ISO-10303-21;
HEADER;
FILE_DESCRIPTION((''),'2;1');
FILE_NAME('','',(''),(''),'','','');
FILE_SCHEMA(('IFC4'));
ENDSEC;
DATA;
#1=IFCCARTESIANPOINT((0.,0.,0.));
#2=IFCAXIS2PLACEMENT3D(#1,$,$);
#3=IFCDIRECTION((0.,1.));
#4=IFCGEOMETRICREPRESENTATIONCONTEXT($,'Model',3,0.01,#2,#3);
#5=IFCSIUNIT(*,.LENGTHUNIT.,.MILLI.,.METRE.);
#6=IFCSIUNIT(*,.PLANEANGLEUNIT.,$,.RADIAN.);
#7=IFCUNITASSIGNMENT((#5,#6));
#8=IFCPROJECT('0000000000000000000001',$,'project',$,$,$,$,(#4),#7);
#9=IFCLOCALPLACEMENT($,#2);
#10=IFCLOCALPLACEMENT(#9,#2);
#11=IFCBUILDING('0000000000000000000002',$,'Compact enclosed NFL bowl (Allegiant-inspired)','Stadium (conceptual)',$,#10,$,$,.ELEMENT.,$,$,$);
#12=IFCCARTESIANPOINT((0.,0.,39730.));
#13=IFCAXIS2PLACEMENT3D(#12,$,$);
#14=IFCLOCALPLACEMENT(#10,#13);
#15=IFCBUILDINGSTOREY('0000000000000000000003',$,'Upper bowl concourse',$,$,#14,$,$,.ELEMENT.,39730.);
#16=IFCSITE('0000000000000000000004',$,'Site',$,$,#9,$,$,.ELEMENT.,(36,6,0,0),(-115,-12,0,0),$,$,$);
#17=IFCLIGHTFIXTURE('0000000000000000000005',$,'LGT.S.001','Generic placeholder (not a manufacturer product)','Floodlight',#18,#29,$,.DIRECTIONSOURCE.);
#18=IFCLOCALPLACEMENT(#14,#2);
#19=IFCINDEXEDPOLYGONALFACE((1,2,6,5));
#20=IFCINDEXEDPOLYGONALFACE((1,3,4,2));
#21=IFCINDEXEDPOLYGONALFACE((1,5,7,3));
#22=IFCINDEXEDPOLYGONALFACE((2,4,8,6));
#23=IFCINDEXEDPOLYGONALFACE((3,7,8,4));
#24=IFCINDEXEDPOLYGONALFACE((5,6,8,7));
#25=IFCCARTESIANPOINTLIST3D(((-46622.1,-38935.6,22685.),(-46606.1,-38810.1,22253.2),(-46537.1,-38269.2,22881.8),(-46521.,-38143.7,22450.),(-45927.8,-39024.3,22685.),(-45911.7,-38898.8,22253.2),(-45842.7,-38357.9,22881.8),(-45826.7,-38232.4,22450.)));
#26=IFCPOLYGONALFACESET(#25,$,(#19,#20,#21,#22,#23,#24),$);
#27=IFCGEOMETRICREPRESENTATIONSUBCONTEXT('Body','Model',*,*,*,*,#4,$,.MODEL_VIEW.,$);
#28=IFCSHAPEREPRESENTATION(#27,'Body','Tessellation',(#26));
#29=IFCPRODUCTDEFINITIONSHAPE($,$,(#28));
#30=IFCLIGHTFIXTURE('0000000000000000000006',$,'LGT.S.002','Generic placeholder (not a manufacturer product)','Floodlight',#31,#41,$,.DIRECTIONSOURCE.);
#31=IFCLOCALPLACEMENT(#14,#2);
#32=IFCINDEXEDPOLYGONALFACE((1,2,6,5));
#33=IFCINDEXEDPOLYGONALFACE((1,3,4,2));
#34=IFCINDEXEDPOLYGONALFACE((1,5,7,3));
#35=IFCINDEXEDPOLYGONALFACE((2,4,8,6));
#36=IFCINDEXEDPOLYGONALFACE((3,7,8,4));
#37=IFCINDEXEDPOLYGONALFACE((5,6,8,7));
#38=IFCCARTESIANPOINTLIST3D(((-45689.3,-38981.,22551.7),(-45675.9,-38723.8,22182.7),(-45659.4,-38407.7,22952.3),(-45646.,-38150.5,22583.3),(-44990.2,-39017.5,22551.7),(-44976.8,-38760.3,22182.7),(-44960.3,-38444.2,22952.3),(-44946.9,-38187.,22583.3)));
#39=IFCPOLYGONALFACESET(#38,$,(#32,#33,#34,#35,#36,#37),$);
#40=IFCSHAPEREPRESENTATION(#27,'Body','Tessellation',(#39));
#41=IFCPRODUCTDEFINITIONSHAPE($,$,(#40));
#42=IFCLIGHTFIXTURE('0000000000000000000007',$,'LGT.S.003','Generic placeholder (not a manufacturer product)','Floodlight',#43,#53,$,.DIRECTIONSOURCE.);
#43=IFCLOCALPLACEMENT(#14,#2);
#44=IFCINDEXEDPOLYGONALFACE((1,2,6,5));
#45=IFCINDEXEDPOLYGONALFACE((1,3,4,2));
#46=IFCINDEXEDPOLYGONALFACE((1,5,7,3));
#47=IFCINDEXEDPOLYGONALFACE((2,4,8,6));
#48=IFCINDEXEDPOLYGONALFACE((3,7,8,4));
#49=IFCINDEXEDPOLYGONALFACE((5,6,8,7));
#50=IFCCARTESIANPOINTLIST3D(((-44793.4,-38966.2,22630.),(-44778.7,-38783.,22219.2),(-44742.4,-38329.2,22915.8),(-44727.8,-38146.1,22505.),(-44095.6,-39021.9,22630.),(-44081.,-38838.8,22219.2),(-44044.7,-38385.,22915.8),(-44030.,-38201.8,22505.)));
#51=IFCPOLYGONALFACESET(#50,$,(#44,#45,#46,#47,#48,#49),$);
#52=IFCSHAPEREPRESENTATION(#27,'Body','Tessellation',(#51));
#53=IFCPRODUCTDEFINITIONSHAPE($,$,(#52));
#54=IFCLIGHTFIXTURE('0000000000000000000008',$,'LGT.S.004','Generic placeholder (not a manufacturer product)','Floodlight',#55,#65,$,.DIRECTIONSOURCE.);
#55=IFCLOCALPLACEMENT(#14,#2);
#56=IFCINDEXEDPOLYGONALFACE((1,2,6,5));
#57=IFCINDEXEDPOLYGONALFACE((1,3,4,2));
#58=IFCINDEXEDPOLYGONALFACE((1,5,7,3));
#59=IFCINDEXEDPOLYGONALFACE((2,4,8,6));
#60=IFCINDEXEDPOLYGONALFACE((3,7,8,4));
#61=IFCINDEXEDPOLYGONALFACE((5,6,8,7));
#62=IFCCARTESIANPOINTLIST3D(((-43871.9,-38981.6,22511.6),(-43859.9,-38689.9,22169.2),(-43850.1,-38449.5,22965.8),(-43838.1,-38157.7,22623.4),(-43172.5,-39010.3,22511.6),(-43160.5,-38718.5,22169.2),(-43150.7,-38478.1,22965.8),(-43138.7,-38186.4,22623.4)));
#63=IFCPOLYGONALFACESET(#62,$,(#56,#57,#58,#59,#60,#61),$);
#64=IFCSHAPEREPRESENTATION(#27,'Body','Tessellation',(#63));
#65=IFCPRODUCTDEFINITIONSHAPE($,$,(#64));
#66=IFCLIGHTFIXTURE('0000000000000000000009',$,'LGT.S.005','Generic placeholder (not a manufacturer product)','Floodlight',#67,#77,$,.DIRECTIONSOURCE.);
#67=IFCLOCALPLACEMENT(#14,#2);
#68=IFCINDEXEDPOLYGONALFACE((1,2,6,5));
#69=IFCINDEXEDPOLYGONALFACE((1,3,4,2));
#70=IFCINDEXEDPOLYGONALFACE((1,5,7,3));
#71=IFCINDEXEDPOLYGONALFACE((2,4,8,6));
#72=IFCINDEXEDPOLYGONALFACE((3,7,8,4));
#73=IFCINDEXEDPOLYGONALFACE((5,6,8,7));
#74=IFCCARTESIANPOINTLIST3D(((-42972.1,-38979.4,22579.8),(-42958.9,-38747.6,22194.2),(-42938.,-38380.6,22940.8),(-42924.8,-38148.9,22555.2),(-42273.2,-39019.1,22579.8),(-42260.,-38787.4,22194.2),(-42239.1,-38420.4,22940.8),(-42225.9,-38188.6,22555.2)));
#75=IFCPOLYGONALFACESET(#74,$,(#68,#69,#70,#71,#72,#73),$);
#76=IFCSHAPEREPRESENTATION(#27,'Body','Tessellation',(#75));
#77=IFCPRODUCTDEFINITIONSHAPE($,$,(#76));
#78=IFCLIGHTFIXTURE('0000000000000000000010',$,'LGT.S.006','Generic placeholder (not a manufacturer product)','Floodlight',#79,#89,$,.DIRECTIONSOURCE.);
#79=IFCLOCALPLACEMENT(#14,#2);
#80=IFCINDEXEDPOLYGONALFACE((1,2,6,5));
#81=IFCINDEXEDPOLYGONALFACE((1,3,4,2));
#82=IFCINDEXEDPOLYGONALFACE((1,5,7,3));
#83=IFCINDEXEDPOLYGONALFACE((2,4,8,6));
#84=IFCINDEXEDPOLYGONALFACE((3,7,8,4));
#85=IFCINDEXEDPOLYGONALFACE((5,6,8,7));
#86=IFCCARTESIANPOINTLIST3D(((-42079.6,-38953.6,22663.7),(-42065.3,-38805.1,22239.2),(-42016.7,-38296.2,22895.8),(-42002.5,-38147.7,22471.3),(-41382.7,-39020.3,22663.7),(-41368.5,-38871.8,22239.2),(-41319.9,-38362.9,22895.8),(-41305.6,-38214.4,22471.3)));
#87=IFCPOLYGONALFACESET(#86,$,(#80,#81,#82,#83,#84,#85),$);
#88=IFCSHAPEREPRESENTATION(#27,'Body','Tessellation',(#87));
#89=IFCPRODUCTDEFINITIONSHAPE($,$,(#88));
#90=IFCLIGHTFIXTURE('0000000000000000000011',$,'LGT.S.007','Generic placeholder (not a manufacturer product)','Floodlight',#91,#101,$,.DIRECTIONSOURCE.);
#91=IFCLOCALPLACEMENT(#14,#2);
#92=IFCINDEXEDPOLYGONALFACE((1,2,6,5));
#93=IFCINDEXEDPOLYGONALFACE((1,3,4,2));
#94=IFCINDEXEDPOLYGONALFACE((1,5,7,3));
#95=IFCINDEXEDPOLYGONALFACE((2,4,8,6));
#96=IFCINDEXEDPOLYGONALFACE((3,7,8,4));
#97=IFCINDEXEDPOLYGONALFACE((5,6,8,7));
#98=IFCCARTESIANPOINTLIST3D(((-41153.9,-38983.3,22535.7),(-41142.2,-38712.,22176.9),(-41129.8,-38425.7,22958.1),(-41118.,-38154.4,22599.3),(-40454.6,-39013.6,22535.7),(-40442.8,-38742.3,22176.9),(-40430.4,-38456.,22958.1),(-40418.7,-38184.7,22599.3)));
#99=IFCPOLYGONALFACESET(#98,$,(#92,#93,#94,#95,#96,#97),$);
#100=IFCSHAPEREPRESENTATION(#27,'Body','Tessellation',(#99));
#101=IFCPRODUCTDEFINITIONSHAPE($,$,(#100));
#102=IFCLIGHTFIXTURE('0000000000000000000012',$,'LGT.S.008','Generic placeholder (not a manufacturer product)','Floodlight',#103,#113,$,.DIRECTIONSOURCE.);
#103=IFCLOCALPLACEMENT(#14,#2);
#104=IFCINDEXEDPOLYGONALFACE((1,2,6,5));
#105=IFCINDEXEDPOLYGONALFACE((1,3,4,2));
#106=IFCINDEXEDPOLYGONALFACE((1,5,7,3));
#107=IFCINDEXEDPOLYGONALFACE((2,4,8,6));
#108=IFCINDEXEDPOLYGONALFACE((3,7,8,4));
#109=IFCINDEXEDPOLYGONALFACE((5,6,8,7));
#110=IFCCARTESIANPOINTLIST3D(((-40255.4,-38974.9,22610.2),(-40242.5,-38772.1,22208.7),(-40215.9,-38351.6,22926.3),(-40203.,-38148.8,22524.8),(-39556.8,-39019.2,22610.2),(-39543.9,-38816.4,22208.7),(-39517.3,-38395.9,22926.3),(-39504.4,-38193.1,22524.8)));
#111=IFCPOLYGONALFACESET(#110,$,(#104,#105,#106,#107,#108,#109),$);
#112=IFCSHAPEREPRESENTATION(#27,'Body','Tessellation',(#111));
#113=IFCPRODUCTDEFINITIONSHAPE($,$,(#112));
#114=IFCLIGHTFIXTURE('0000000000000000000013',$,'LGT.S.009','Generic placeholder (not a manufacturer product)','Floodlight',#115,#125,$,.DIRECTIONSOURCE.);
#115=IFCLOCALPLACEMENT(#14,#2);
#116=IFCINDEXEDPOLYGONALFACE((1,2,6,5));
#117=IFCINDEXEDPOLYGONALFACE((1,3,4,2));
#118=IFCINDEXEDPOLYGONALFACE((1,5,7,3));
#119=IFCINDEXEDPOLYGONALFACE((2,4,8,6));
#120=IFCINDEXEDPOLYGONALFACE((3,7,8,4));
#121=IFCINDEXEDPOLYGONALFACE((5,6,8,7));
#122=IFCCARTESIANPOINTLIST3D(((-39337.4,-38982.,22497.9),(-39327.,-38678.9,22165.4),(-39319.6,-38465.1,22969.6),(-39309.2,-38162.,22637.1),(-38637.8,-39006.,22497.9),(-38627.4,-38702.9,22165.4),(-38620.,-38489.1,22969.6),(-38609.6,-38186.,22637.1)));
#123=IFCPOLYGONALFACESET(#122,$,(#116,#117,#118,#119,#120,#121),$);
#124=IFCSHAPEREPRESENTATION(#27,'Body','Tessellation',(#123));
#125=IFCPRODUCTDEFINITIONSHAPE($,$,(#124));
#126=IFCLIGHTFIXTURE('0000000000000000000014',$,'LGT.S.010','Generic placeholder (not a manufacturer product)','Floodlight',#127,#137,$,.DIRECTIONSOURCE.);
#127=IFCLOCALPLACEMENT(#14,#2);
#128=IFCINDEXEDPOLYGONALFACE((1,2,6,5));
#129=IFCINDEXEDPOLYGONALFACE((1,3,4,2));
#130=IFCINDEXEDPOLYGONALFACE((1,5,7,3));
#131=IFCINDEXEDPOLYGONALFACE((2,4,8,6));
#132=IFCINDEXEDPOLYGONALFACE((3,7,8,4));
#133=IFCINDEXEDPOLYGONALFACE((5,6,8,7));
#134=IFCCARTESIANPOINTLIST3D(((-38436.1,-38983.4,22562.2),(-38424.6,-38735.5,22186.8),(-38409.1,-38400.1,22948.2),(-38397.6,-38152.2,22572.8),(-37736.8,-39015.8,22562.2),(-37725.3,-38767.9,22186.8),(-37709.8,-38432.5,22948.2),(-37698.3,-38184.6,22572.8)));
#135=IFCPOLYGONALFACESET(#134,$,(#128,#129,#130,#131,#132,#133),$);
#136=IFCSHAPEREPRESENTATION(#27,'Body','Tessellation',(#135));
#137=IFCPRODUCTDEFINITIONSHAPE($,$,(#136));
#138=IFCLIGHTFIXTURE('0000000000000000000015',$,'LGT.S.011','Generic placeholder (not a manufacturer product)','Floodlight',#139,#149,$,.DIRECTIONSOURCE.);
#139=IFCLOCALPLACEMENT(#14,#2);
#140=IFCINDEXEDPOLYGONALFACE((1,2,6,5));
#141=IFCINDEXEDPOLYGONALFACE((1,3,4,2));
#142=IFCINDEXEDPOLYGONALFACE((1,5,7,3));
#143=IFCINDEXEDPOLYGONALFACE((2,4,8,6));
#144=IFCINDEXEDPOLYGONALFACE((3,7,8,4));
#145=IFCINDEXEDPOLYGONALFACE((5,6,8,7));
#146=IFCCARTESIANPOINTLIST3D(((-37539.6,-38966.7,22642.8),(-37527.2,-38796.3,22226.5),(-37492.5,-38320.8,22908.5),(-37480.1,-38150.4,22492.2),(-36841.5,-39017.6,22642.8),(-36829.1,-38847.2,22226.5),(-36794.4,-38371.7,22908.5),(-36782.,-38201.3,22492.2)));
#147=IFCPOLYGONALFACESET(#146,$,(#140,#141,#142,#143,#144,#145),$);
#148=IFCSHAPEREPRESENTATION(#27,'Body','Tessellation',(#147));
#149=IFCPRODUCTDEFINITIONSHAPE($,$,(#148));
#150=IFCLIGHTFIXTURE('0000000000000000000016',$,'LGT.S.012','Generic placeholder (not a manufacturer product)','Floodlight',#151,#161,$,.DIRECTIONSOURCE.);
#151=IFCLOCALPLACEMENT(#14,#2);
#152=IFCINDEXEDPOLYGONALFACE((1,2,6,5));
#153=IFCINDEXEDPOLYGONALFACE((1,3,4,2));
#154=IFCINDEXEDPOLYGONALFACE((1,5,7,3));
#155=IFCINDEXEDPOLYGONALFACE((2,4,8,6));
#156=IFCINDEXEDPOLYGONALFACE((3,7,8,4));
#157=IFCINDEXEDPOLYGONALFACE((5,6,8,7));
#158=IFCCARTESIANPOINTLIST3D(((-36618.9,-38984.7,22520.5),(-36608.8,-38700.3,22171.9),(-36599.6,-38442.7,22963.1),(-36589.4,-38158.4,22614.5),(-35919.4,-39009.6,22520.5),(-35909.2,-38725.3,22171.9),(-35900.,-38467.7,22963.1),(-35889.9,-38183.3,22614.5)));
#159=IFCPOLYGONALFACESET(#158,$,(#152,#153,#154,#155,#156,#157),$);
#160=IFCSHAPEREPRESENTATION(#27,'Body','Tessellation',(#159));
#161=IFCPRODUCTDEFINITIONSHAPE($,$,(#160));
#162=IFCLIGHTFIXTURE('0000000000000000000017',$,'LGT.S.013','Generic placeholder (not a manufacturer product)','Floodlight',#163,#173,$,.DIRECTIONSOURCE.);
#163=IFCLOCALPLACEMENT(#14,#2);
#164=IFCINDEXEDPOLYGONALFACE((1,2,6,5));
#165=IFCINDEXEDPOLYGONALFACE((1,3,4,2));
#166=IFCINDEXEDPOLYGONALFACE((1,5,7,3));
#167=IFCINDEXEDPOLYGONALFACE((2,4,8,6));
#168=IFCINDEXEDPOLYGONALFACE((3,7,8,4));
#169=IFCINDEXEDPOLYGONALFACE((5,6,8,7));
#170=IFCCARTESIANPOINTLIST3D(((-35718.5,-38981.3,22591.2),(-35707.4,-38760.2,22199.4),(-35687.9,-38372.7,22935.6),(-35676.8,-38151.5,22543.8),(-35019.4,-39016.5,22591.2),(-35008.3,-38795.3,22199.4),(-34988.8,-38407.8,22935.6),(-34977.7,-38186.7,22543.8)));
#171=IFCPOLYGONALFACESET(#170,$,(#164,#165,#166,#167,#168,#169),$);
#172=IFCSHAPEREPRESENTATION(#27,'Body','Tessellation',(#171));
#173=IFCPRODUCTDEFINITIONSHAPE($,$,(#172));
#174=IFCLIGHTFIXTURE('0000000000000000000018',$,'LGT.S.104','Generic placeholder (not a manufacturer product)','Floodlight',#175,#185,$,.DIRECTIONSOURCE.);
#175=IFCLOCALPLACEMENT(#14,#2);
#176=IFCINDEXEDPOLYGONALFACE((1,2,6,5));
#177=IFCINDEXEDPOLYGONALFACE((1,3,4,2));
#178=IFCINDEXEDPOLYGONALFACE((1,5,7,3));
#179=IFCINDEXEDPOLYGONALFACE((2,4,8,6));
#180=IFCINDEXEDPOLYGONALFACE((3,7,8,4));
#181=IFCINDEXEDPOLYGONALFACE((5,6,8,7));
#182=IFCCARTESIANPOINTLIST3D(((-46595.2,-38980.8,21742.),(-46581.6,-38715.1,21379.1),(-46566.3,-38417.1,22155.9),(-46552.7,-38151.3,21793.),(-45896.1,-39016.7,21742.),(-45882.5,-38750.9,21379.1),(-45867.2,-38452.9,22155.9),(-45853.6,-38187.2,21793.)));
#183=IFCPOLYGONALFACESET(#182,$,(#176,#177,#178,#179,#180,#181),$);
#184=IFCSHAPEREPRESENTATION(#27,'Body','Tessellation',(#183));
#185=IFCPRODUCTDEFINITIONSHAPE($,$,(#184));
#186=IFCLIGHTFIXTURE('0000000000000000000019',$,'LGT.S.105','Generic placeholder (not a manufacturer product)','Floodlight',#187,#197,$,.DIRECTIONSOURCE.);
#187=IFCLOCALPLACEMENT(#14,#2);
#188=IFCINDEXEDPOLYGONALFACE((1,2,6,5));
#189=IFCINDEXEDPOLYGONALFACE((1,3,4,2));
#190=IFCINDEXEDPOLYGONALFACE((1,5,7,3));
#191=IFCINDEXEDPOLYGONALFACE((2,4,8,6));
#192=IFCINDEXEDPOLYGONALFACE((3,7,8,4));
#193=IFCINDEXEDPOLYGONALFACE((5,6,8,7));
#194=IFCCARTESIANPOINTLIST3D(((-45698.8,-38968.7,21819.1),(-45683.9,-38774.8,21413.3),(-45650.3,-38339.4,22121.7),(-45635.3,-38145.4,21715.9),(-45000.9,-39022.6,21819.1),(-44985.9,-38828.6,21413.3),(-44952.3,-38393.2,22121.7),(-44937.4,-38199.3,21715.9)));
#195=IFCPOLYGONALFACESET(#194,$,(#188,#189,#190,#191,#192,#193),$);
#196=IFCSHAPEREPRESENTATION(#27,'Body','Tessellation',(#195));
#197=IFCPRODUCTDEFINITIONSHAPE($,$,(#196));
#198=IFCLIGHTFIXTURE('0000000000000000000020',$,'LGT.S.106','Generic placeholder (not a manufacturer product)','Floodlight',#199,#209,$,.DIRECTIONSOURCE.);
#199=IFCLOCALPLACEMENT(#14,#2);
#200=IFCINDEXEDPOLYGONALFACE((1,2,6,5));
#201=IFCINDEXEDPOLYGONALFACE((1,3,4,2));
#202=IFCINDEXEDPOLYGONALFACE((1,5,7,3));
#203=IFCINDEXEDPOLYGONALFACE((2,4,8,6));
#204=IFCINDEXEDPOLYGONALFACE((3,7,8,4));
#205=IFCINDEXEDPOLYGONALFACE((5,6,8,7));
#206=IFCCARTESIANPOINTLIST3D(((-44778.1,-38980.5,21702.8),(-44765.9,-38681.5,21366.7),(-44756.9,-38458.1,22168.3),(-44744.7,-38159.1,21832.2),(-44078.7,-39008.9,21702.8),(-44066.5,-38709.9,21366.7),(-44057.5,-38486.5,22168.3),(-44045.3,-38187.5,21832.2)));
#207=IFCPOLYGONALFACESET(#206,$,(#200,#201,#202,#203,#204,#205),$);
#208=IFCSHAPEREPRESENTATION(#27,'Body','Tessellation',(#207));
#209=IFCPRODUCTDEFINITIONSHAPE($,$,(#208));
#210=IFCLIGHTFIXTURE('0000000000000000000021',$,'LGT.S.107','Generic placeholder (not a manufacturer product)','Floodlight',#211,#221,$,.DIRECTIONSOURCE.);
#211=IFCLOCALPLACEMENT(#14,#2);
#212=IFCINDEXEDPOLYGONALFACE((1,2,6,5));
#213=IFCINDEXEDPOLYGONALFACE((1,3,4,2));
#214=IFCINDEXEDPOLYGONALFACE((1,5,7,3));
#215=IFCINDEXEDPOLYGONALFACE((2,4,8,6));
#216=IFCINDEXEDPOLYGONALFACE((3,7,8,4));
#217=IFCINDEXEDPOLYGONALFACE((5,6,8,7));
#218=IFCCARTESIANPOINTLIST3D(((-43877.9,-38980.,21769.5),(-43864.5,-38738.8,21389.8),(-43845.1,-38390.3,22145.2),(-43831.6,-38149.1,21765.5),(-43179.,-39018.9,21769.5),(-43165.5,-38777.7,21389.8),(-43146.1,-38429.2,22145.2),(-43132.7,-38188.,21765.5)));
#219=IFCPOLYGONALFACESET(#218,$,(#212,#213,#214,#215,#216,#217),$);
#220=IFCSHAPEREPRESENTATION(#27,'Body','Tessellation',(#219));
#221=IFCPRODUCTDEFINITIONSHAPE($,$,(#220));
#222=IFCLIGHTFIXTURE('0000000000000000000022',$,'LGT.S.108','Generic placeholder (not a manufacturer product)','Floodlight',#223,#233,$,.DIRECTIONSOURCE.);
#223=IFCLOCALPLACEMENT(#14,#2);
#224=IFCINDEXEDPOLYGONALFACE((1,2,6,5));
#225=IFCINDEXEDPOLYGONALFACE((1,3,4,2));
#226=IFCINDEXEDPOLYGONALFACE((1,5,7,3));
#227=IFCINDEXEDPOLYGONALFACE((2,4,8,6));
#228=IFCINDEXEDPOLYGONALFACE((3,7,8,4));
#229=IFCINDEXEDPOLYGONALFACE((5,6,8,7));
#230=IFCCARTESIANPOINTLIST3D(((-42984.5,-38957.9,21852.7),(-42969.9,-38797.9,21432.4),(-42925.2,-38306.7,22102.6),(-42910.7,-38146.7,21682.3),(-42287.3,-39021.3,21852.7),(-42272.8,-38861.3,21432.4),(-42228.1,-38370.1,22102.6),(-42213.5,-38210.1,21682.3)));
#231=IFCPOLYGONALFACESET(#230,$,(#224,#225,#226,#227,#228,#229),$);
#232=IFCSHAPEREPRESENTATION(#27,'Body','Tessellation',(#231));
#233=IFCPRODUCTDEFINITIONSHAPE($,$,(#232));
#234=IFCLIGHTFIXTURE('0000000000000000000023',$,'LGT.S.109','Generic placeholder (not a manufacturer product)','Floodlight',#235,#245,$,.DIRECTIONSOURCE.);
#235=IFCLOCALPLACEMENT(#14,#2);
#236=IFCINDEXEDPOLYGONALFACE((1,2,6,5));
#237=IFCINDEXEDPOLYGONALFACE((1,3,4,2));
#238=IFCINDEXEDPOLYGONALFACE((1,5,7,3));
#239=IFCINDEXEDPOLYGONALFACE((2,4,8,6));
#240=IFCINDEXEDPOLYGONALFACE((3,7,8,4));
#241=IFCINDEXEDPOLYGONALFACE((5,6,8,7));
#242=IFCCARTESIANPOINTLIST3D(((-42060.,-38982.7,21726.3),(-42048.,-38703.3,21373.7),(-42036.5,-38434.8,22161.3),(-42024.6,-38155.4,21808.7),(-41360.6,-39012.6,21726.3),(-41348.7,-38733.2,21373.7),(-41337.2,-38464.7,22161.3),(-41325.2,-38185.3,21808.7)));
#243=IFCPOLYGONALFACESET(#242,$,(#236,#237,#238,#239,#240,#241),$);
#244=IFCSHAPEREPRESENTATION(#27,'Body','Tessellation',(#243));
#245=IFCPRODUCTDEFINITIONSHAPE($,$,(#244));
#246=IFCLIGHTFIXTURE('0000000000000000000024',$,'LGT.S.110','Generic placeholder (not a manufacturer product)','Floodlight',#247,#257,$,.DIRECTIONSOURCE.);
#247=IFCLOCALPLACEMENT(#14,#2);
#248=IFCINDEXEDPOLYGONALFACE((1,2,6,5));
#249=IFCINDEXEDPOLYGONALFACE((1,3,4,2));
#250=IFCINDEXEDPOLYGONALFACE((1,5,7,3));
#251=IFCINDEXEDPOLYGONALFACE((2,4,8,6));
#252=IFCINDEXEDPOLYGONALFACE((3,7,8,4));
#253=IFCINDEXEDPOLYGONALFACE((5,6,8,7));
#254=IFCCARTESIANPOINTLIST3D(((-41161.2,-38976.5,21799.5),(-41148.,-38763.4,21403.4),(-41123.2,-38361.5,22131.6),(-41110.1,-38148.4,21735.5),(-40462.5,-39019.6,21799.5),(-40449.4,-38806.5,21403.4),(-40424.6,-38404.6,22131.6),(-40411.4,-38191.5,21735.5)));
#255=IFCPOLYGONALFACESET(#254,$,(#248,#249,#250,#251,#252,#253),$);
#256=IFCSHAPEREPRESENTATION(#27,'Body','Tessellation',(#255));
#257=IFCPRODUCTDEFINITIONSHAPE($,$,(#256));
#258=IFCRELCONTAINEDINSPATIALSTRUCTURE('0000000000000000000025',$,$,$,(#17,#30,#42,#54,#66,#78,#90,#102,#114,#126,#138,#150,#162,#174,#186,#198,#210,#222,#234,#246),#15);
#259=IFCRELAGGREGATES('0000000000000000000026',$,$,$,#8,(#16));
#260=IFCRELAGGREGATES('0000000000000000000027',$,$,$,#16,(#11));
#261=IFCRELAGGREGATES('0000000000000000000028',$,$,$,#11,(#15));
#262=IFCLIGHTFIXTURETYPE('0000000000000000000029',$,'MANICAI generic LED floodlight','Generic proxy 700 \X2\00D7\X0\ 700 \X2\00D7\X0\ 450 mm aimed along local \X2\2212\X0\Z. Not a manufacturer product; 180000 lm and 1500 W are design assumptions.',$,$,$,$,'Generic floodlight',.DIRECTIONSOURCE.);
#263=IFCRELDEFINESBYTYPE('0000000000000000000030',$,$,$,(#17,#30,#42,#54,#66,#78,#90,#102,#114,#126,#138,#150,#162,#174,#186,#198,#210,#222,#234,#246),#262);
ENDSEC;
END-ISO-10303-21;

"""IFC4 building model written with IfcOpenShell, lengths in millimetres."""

from ifc_helpers import new_model, si_unit, direction, frame, origin, place, context, subcontext, project, spatial, rectangle, extrude, source, transform, mapped, type_object, type_shapes, element, save


model = new_model("IFC4")

# Units and contexts
model_context = context("Model", 3, precision=0.01, world=origin(), true_north=direction((0.0, 1.0)))
body_context = subcontext(model_context, "Body", "Model", "MODEL_VIEW")
ifc_project = project(units=[si_unit("LENGTHUNIT", "METRE", prefix="MILLI"), si_unit("PLANEANGLEUNIT", "RADIAN")], contexts=[model_context])

# Site, building, storey
site_placement = place(None, origin())
site = spatial("IfcSite", under=ifc_project, at=site_placement, Name="Site", CompositionType="ELEMENT", RefLatitude=(36, 6, 0, 0), RefLongitude=(-115, -12, 0, 0))
building_placement = place(site_placement, origin())
building = spatial("IfcBuilding", under=site, at=building_placement, Name="Compact enclosed NFL bowl (Allegiant-inspired)", Description="Stadium (conceptual)", CompositionType="ELEMENT")
storey_placement = place(building_placement, frame((0.0, 0.0, 39730.0)))
storey = spatial("IfcBuildingStorey", under=building, at=storey_placement, Name="Upper bowl concourse", CompositionType="ELEMENT", Elevation=39730.0)

# Light fixtures
light_fixture_type = type_object("IfcLightFixtureType", Name="MANICAI generic LED floodlight", Description="Generic proxy 700 × 700 × 450 mm aimed along local −Z. Not a manufacturer product; 180000 lm and 1500 W are design assumptions.", ElementType="Generic floodlight", PredefinedType="DIRECTIONSOURCE")
shared_shape = source(origin(), body_context, "Body", "SweptSolid", [
    extrude(rectangle(XDim=700.0, YDim=700.0), frame((0.0, 0.0, -225.0)), (0.0, 0.0, 1.0), 450.0),
])
type_shapes(light_fixture_type, [shared_shape])
for number, where, z_axis, x_axis, name in (
    (1, (-46224.4, -38584.0, 22567.5), (-0.035604, -0.278848, 0.959675), (0.991947, -0.126653, 0.0), "LGT.S.001"),
    (2, (-45318.1, -38584.0, 22567.5), (-0.029827, -0.571537, 0.820034), (0.998641, -0.052116, 0.0), "LGT.S.002"),
    (3, (-44411.7, -38584.0, 22567.5), (-0.032539, -0.406954, 0.912869), (0.996819, -0.079703, 0.0), "LGT.S.003"),
    (4, (-43505.3, -38584.0, 22567.5), (-0.026567, -0.64839, 0.760844), (0.999162, -0.040939, 0.0), "LGT.S.004"),
    (5, (-42599.0, -38584.0, 22567.5), (-0.029292, -0.514923, 0.856736), (0.998386, -0.056794, 0.0), "LGT.S.005"),
    (6, (-41692.6, -38584.0, 22567.5), (-0.03157, -0.330066, 0.94343), (0.995457, -0.095212, 0.0), "LGT.S.006"),
    (7, (-40786.3, -38584.0, 22567.5), (-0.026101, -0.602985, 0.797325), (0.999064, -0.043245, 0.0), "LGT.S.007"),
    (8, (-39879.9, -38584.0, 22567.5), (-0.028558, -0.45066, 0.892239), (0.997998, -0.063243, 0.0), "LGT.S.008"),
    (9, (-38973.5, -38584.0, 22567.5), (-0.023112, -0.673464, 0.738859), (0.999412, -0.034297, 0.0), "LGT.S.009"),
    (10, (-38067.2, -38584.0, 22567.5), (-0.025488, -0.55085, 0.834215), (0.998931, -0.04622, 0.0), "LGT.S.010"),
    (11, (-37160.8, -38584.0, 22567.5), (-0.027594, -0.378536, 0.925175), (0.997354, -0.072703, 0.0), "LGT.S.011"),
    (12, (-36254.4, -38584.0, 22567.5), (-0.022544, -0.631856, 0.774758), (0.999364, -0.035656, 0.0), "LGT.S.012"),
    (13, (-35348.1, -38584.0, 22567.5), (-0.0247, -0.491356, 0.870608), (0.998739, -0.050205, 0.0), "LGT.S.013"),
    (14, (-46224.4, -38584.0, 21767.5), (-0.030307, -0.590562, 0.806423), (0.998686, -0.051252, 0.0), "LGT.S.104"),
    (15, (-45318.1, -38584.0, 21767.5), (-0.033226, -0.430942, 0.901768), (0.997041, -0.076873, 0.0), "LGT.S.105"),
    (16, (-44411.7, -38584.0, 21767.5), (-0.026969, -0.664408, 0.746883), (0.999177, -0.040557, 0.0), "LGT.S.106"),
    (17, (-43505.3, -38584.0, 21767.5), (-0.029845, -0.535899, 0.843754), (0.998453, -0.055605, 0.0), "LGT.S.107"),
    (18, (-42599.0, -38584.0, 21767.5), (-0.032352, -0.355602, 0.934077), (0.995887, -0.090603, 0.0), "LGT.S.108"),
    (19, (-41692.6, -38584.0, 21767.5), (-0.026559, -0.620831, 0.783494), (0.999086, -0.04274, 0.0), "LGT.S.109"),
    (20, (-40786.3, -38584.0, 21767.5), (-0.029191, -0.473549, 0.880284), (0.998105, -0.061526, 0.0), "LGT.S.110"),
):
    element("IfcLightFixture", number, at=place(storey_placement, frame(where, z_axis=z_axis, x_axis=x_axis)), inside=storey, type_object=light_fixture_type, Name=name, Description="Generic placeholder (not a manufacturer product)", ObjectType="Floodlight", PredefinedType="DIRECTIONSOURCE", context=body_context, shape_type="MappedRepresentation", body=[
        mapped(shared_shape, transform((0.0, 0.0, 0.0))),
    ])

save(model, "model.ifc")
